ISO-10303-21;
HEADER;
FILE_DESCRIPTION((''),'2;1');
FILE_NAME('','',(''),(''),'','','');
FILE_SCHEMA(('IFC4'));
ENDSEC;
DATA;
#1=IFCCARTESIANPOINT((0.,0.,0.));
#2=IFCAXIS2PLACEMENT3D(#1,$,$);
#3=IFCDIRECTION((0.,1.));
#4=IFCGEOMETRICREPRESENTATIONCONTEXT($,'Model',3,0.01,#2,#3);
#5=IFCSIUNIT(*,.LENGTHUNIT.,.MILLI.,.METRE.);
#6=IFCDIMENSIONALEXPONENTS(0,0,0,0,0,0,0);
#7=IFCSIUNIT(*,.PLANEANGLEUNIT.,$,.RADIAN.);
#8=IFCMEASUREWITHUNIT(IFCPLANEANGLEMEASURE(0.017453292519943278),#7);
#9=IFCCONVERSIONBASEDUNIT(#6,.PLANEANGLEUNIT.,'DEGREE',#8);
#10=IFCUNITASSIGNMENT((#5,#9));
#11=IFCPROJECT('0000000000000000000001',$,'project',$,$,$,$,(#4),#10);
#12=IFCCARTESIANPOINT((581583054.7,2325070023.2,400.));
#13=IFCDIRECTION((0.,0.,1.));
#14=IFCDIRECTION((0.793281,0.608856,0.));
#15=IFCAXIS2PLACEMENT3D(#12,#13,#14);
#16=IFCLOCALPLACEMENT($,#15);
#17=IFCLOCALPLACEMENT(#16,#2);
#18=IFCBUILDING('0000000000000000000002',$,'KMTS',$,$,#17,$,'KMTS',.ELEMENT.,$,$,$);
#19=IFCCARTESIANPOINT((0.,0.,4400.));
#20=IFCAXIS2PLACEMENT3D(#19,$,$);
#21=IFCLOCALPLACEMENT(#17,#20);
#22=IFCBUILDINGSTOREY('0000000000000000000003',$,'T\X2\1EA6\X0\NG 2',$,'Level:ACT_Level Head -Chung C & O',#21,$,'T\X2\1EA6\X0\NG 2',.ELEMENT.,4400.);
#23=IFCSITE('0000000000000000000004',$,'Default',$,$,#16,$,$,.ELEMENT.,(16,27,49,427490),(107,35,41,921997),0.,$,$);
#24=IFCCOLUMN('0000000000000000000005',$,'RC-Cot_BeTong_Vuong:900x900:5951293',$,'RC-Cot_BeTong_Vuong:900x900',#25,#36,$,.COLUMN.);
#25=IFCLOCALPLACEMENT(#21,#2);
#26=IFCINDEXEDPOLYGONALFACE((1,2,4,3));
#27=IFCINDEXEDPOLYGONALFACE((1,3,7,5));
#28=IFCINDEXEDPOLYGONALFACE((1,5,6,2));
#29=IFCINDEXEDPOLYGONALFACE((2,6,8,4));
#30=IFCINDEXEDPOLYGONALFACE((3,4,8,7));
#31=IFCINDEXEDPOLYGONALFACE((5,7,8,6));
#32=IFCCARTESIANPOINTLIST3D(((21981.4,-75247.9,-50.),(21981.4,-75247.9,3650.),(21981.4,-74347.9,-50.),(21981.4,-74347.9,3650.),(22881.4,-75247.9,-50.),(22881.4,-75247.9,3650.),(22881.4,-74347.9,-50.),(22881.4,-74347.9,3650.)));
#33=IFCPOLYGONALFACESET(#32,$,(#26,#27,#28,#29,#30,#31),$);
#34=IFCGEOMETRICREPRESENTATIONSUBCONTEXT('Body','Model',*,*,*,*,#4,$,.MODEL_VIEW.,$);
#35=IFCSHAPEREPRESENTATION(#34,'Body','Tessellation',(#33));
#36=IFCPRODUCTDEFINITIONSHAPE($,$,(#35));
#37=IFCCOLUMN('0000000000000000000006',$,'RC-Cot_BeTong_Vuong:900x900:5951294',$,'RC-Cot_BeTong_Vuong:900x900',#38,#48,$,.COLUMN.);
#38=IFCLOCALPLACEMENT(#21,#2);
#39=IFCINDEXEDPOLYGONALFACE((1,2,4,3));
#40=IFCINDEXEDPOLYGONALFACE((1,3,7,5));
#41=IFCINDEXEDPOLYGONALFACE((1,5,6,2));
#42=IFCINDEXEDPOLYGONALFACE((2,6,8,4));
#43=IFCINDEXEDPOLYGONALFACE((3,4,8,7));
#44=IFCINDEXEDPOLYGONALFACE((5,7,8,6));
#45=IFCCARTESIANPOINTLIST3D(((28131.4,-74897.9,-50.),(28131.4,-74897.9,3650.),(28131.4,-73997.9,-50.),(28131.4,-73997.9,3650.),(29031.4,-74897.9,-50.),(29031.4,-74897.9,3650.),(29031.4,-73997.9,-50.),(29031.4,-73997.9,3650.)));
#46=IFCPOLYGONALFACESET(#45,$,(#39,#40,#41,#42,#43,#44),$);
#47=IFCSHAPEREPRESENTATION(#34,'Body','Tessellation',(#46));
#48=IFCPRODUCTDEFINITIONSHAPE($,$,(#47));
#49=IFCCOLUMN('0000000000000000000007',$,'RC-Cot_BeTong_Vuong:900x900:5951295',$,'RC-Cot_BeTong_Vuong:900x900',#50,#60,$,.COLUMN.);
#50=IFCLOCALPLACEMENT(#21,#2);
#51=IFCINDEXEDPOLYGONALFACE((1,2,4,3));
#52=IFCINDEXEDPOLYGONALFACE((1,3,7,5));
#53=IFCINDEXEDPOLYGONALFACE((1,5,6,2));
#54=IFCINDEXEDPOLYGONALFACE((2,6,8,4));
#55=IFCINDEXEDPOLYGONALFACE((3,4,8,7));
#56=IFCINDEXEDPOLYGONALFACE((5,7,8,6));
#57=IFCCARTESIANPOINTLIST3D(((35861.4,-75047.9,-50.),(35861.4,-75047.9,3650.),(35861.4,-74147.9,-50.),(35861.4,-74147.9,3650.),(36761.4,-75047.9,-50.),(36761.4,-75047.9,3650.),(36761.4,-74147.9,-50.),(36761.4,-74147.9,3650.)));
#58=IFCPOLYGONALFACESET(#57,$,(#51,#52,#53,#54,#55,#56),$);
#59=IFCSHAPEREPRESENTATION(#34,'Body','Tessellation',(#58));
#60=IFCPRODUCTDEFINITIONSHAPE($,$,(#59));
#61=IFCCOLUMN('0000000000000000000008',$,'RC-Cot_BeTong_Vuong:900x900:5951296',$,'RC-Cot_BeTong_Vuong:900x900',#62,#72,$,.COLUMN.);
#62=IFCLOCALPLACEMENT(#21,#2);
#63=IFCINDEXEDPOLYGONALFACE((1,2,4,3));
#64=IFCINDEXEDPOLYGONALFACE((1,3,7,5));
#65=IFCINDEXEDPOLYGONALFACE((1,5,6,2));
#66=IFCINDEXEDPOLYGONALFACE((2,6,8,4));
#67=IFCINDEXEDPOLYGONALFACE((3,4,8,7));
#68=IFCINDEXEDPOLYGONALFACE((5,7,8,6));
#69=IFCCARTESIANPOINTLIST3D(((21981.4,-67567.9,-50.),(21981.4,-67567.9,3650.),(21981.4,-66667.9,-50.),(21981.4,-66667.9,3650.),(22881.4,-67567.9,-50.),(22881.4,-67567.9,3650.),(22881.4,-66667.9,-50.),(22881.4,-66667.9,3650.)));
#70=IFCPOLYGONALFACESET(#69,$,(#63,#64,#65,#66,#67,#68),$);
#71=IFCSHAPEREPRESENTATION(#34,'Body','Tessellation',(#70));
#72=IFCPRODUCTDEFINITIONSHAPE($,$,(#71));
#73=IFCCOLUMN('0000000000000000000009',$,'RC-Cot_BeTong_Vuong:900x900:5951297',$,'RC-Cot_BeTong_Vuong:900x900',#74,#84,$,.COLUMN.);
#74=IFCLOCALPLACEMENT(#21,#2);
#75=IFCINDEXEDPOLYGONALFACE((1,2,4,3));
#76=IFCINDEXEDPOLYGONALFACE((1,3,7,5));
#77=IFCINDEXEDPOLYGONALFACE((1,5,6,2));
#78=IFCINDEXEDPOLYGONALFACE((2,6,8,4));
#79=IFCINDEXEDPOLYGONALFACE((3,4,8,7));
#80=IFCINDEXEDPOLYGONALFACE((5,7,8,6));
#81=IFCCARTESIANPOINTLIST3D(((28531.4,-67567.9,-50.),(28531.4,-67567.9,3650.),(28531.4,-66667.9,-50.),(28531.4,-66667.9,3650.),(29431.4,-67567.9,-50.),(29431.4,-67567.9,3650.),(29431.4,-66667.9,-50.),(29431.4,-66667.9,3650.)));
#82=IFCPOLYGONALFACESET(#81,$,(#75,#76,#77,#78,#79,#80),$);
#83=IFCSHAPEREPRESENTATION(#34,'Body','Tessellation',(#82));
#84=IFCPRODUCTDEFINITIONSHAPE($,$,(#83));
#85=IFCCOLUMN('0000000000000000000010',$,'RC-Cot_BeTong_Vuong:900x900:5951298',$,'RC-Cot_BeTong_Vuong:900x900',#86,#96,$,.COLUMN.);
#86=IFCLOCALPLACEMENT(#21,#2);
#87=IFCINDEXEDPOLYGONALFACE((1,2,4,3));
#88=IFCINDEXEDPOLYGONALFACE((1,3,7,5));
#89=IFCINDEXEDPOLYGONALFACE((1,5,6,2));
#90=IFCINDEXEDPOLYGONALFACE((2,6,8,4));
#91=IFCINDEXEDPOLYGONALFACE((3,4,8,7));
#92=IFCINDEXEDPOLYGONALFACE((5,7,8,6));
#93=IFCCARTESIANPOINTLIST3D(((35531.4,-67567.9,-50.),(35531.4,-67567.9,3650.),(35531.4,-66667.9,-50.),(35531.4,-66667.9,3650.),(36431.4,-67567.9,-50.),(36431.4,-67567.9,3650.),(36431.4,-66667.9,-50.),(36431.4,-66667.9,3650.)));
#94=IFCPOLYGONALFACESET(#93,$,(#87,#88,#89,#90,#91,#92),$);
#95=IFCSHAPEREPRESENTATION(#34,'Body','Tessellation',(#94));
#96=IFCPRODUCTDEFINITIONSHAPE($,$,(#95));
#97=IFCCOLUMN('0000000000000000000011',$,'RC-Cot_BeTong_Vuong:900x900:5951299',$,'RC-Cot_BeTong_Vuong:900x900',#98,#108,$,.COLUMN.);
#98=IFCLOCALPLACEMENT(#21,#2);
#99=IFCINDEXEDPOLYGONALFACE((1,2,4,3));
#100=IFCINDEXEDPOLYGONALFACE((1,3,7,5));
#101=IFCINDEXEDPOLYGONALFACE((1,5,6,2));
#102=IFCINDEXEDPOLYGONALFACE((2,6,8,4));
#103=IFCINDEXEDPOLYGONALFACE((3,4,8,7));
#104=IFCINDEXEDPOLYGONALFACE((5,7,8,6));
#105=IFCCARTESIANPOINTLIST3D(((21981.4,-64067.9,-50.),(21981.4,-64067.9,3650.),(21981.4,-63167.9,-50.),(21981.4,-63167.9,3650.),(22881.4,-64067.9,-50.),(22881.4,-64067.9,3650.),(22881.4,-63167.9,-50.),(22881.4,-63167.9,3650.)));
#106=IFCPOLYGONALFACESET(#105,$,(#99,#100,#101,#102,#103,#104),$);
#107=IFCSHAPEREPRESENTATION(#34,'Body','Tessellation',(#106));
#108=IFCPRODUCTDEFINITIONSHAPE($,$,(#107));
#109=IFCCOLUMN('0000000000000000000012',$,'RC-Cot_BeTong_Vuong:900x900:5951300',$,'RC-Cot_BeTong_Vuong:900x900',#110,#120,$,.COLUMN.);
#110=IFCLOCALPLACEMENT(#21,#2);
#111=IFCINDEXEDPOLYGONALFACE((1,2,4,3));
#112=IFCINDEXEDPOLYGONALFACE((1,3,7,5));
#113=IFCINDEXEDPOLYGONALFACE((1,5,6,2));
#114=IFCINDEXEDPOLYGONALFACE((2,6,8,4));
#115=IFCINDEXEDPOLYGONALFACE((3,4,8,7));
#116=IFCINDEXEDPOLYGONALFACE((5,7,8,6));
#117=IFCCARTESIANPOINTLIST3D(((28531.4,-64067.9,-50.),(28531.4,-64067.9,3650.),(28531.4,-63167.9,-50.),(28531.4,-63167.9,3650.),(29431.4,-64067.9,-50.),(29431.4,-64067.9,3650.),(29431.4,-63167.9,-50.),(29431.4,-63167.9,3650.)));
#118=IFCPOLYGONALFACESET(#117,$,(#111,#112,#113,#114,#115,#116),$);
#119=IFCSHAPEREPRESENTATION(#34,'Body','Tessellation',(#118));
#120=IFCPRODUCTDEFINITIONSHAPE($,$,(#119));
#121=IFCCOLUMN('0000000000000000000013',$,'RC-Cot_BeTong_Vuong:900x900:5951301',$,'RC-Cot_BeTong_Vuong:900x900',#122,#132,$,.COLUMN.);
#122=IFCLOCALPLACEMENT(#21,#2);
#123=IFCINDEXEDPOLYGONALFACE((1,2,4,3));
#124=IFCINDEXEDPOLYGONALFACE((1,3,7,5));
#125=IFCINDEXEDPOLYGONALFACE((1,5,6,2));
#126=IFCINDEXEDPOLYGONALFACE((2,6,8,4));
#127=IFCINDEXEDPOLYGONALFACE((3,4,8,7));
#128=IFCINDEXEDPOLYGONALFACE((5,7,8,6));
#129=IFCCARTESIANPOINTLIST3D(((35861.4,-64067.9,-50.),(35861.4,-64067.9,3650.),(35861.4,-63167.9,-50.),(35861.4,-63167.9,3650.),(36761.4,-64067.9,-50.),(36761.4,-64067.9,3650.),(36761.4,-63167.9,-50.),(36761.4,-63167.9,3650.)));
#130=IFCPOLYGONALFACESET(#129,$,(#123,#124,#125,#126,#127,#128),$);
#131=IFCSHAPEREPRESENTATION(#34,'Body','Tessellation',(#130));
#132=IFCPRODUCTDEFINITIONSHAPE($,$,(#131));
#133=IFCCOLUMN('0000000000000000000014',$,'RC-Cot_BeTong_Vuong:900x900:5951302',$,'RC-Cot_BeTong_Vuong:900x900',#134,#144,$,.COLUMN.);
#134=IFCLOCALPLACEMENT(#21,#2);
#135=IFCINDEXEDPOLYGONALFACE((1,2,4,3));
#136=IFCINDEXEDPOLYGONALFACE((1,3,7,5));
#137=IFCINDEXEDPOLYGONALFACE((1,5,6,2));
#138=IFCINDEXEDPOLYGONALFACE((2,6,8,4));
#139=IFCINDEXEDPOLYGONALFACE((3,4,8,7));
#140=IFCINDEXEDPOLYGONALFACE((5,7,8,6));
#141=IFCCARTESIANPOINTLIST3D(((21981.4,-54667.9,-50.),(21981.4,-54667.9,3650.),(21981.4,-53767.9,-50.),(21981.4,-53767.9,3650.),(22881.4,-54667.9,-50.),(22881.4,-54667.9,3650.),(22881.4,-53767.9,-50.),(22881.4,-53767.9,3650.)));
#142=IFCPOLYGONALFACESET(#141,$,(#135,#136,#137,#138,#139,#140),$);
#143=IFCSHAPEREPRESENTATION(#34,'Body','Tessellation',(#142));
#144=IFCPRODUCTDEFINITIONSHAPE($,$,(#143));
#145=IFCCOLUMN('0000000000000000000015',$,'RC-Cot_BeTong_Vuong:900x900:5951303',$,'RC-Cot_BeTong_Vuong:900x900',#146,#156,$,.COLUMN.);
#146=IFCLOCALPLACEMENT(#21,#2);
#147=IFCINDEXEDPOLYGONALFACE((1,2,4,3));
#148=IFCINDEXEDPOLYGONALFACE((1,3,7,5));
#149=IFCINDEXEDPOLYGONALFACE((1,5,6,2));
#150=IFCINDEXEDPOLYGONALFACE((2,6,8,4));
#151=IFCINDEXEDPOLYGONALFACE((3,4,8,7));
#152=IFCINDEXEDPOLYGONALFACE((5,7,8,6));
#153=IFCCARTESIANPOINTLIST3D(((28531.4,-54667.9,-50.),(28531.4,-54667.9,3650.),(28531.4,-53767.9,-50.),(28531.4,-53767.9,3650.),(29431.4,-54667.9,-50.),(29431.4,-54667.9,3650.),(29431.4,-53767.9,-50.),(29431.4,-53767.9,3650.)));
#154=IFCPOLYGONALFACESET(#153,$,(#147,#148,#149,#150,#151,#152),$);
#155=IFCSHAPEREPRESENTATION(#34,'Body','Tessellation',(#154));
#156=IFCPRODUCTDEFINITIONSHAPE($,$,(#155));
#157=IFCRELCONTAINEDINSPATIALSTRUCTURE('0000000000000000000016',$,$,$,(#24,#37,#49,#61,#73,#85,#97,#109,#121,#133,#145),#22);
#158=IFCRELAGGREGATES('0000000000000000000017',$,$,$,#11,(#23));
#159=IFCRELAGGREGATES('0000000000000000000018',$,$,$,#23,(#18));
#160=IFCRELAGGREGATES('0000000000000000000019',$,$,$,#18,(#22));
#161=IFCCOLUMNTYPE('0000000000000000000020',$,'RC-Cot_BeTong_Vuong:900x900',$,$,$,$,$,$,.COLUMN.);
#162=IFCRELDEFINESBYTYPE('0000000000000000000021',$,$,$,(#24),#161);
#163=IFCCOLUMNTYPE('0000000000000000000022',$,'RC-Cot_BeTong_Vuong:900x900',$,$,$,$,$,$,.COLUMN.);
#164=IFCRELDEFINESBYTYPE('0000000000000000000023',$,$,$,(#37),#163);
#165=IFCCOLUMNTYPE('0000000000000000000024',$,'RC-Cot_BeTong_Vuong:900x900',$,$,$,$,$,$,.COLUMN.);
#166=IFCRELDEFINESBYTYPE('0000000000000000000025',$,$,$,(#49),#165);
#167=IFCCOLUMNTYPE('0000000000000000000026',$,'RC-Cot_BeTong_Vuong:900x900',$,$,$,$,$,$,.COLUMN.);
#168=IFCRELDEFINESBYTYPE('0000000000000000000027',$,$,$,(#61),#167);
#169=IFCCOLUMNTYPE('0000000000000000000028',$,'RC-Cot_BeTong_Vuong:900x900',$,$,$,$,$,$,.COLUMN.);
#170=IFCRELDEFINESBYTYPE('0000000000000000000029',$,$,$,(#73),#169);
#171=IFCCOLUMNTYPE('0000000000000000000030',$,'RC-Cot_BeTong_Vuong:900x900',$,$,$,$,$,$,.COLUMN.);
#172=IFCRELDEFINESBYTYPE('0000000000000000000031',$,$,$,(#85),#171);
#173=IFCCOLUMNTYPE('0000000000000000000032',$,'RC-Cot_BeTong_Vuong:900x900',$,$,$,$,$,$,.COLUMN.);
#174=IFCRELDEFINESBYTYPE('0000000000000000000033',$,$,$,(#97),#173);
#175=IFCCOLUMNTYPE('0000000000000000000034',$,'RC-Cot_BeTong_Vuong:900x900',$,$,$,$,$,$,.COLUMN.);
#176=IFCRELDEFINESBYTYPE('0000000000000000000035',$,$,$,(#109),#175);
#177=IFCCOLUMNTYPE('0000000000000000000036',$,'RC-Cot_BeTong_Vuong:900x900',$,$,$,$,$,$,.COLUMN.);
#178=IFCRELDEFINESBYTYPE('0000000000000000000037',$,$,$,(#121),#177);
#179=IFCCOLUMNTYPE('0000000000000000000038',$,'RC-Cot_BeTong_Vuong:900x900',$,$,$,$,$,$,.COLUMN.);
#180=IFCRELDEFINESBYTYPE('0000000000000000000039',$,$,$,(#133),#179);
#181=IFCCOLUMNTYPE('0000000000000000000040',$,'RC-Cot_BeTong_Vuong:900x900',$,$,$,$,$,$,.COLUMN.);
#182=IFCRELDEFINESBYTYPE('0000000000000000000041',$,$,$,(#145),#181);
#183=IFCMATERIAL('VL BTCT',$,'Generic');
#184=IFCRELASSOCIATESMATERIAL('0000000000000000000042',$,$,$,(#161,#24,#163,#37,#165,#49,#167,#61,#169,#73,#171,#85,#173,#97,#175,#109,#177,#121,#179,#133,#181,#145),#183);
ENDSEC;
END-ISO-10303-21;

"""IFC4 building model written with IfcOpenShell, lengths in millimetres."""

from ifc_helpers import new_model, entity, si_unit, converted_unit, direction, frame, origin, place, context, subcontext, project, spatial, indexed_curve, outline, extrude, source, transform, mapped, material, type_object, type_shapes, element, save


model = new_model("IFC4")

# Units and contexts
model_context = context("Model", 3, precision=0.01, world=origin(), true_north=direction((0.0, 1.0)))
body_context = subcontext(model_context, "Body", "Model", "MODEL_VIEW")
ifc_project = project(units=[si_unit("LENGTHUNIT", "METRE", prefix="MILLI"), converted_unit("PLANEANGLEUNIT", "DEGREE", entity("IfcPlaneAngleMeasure", 0.017453292519943278), si_unit("PLANEANGLEUNIT", "RADIAN"), dimensions=[0, 0, 0, 0, 0, 0, 0])], contexts=[model_context])

# Site, building, storey
site_placement = place(None, frame((581583054.7, 2325070023.2, 400.0), z_axis=(0.0, 0.0, 1.0), x_axis=(0.793281, 0.608856, 0.0)))
site = spatial("IfcSite", under=ifc_project, at=site_placement, Name="Default", CompositionType="ELEMENT", RefLatitude=(16, 27, 49, 427490), RefLongitude=(107, 35, 41, 921997), RefElevation=0.0)
building_placement = place(site_placement, origin())
building = spatial("IfcBuilding", under=site, at=building_placement, Name="KMTS", LongName="KMTS", CompositionType="ELEMENT")
storey_placement = place(building_placement, frame((0.0, 0.0, 4400.0)))
storey = spatial("IfcBuildingStorey", under=building, at=storey_placement, Name="TẦNG 2", ObjectType="Level:ACT_Level Head -Chung C & O", LongName="TẦNG 2", CompositionType="ELEMENT", Elevation=4400.0)

# Columns
ifc_material_1 = material(Name="VL BTCT", Category="Generic")
column_type_1 = type_object("IfcColumnType", Name="RC-Cot_BeTong_Vuong:900x900", PredefinedType="COLUMN", material=ifc_material_1)
shared_shape_1 = source(origin(), body_context, "Body", "SweptSolid", [
    extrude(outline(indexed_curve([(-450.0, -450.0), (450.0, -450.0), (450.0, 450.0), (-450.0, 450.0), (-450.0, -450.0)], self_intersect=False)), frame((22431.4, -74797.9, 4350.0), z_axis=(0.0, 0.0, 1.0), x_axis=(-1.0, 0.0, 0.0)), (0.0, 0.0, 1.0), 3700.0),
])
type_shapes(column_type_1, [shared_shape_1])
column_1_placement = place(storey_placement, frame((0.0, 0.0, -4400.0)))
element("IfcColumn", 1, at=column_1_placement, inside=storey, type_object=column_type_1, material=ifc_material_1, Name="RC-Cot_BeTong_Vuong:900x900:5951293", ObjectType="RC-Cot_BeTong_Vuong:900x900", PredefinedType="COLUMN", context=body_context, shape_type="MappedRepresentation", body=[
    mapped(shared_shape_1, transform((0.0, 0.0, 0.0), scale=1.0)),
])
column_type_2 = type_object("IfcColumnType", Name="RC-Cot_BeTong_Vuong:900x900", PredefinedType="COLUMN", material=ifc_material_1)
shared_shape_2 = source(origin(), body_context, "Body", "SweptSolid", [
    extrude(outline(indexed_curve([(-450.0, -450.0), (450.0, -450.0), (450.0, 450.0), (-450.0, 450.0), (-450.0, -450.0)], self_intersect=False)), frame((28581.4, -74447.9, 4350.0), z_axis=(0.0, 0.0, 1.0), x_axis=(-1.0, 0.0, 0.0)), (0.0, 0.0, 1.0), 3700.0),
])
type_shapes(column_type_2, [shared_shape_2])
column_2_placement = place(storey_placement, frame((0.0, 0.0, -4400.0)))
element("IfcColumn", 2, at=column_2_placement, inside=storey, type_object=column_type_2, material=ifc_material_1, Name="RC-Cot_BeTong_Vuong:900x900:5951294", ObjectType="RC-Cot_BeTong_Vuong:900x900", PredefinedType="COLUMN", context=body_context, shape_type="MappedRepresentation", body=[
    mapped(shared_shape_2, transform((0.0, 0.0, 0.0), scale=1.0)),
])
column_type_3 = type_object("IfcColumnType", Name="RC-Cot_BeTong_Vuong:900x900", PredefinedType="COLUMN", material=ifc_material_1)
shared_shape_3 = source(origin(), body_context, "Body", "SweptSolid", [
    extrude(outline(indexed_curve([(-450.0, -450.0), (450.0, -450.0), (450.0, 450.0), (-450.0, 450.0), (-450.0, -450.0)], self_intersect=False)), frame((36311.4, -74597.9, 4350.0), z_axis=(0.0, 0.0, 1.0), x_axis=(-1.0, 0.0, 0.0)), (0.0, 0.0, 1.0), 3700.0),
])
type_shapes(column_type_3, [shared_shape_3])
column_3_placement = place(storey_placement, frame((0.0, 0.0, -4400.0)))
element("IfcColumn", 3, at=column_3_placement, inside=storey, type_object=column_type_3, material=ifc_material_1, Name="RC-Cot_BeTong_Vuong:900x900:5951295", ObjectType="RC-Cot_BeTong_Vuong:900x900", PredefinedType="COLUMN", context=body_context, shape_type="MappedRepresentation", body=[
    mapped(shared_shape_3, transform((0.0, 0.0, 0.0), scale=1.0)),
])
column_type_4 = type_object("IfcColumnType", Name="RC-Cot_BeTong_Vuong:900x900", PredefinedType="COLUMN", material=ifc_material_1)
shared_shape_4 = source(origin(), body_context, "Body", "SweptSolid", [
    extrude(outline(indexed_curve([(-450.0, -450.0), (450.0, -450.0), (450.0, 450.0), (-450.0, 450.0), (-450.0, -450.0)], self_intersect=False)), frame((22431.4, -67117.9, 4350.0), z_axis=(0.0, 0.0, 1.0), x_axis=(-1.0, 0.0, 0.0)), (0.0, 0.0, 1.0), 3700.0),
])
type_shapes(column_type_4, [shared_shape_4])
column_4_placement = place(storey_placement, frame((0.0, 0.0, -4400.0)))
element("IfcColumn", 4, at=column_4_placement, inside=storey, type_object=column_type_4, material=ifc_material_1, Name="RC-Cot_BeTong_Vuong:900x900:5951296", ObjectType="RC-Cot_BeTong_Vuong:900x900", PredefinedType="COLUMN", context=body_context, shape_type="MappedRepresentation", body=[
    mapped(shared_shape_4, transform((0.0, 0.0, 0.0), scale=1.0)),
])
column_type_5 = type_object("IfcColumnType", Name="RC-Cot_BeTong_Vuong:900x900", PredefinedType="COLUMN", material=ifc_material_1)
shared_shape_5 = source(origin(), body_context, "Body", "SweptSolid", [
    extrude(outline(indexed_curve([(-450.0, -450.0), (450.0, -450.0), (450.0, 450.0), (-450.0, 450.0), (-450.0, -450.0)], self_intersect=False)), frame((28981.4, -67117.9, 4350.0), z_axis=(0.0, 0.0, 1.0), x_axis=(-1.0, 0.0, 0.0)), (0.0, 0.0, 1.0), 3700.0),
])
type_shapes(column_type_5, [shared_shape_5])
column_5_placement = place(storey_placement, frame((0.0, 0.0, -4400.0)))
element("IfcColumn", 5, at=column_5_placement, inside=storey, type_object=column_type_5, material=ifc_material_1, Name="RC-Cot_BeTong_Vuong:900x900:5951297", ObjectType="RC-Cot_BeTong_Vuong:900x900", PredefinedType="COLUMN", context=body_context, shape_type="MappedRepresentation", body=[
    mapped(shared_shape_5, transform((0.0, 0.0, 0.0), scale=1.0)),
])
column_type_6 = type_object("IfcColumnType", Name="RC-Cot_BeTong_Vuong:900x900", PredefinedType="COLUMN", material=ifc_material_1)
shared_shape_6 = source(origin(), body_context, "Body", "SweptSolid", [
    extrude(outline(indexed_curve([(-450.0, -450.0), (450.0, -450.0), (450.0, 450.0), (-450.0, 450.0), (-450.0, -450.0)], self_intersect=False)), frame((35981.4, -67117.9, 4350.0), z_axis=(0.0, 0.0, 1.0), x_axis=(-1.0, 0.0, 0.0)), (0.0, 0.0, 1.0), 3700.0),
])
type_shapes(column_type_6, [shared_shape_6])
column_6_placement = place(storey_placement, frame((0.0, 0.0, -4400.0)))
element("IfcColumn", 6, at=column_6_placement, inside=storey, type_object=column_type_6, material=ifc_material_1, Name="RC-Cot_BeTong_Vuong:900x900:5951298", ObjectType="RC-Cot_BeTong_Vuong:900x900", PredefinedType="COLUMN", context=body_context, shape_type="MappedRepresentation", body=[
    mapped(shared_shape_6, transform((0.0, 0.0, 0.0), scale=1.0)),
])
column_type_7 = type_object("IfcColumnType", Name="RC-Cot_BeTong_Vuong:900x900", PredefinedType="COLUMN", material=ifc_material_1)
shared_shape_7 = source(origin(), body_context, "Body", "SweptSolid", [
    extrude(outline(indexed_curve([(-450.0, -450.0), (450.0, -450.0), (450.0, 450.0), (-450.0, 450.0), (-450.0, -450.0)], self_intersect=False)), frame((22431.4, -63617.9, 4350.0), z_axis=(0.0, 0.0, 1.0), x_axis=(-1.0, 0.0, 0.0)), (0.0, 0.0, 1.0), 3700.0),
])
type_shapes(column_type_7, [shared_shape_7])
column_7_placement = place(storey_placement, frame((0.0, 0.0, -4400.0)))
element("IfcColumn", 7, at=column_7_placement, inside=storey, type_object=column_type_7, material=ifc_material_1, Name="RC-Cot_BeTong_Vuong:900x900:5951299", ObjectType="RC-Cot_BeTong_Vuong:900x900", PredefinedType="COLUMN", context=body_context, shape_type="MappedRepresentation", body=[
    mapped(shared_shape_7, transform((0.0, 0.0, 0.0), scale=1.0)),
])
column_type_8 = type_object("IfcColumnType", Name="RC-Cot_BeTong_Vuong:900x900", PredefinedType="COLUMN", material=ifc_material_1)
shared_shape_8 = source(origin(), body_context, "Body", "SweptSolid", [
    extrude(outline(indexed_curve([(-450.0, -450.0), (450.0, -450.0), (450.0, 450.0), (-450.0, 450.0), (-450.0, -450.0)], self_intersect=False)), frame((28981.4, -63617.9, 4350.0), z_axis=(0.0, 0.0, 1.0), x_axis=(-1.0, 0.0, 0.0)), (0.0, 0.0, 1.0), 3700.0),
])
type_shapes(column_type_8, [shared_shape_8])
column_8_placement = place(storey_placement, frame((0.0, 0.0, -4400.0)))
element("IfcColumn", 8, at=column_8_placement, inside=storey, type_object=column_type_8, material=ifc_material_1, Name="RC-Cot_BeTong_Vuong:900x900:5951300", ObjectType="RC-Cot_BeTong_Vuong:900x900", PredefinedType="COLUMN", context=body_context, shape_type="MappedRepresentation", body=[
    mapped(shared_shape_8, transform((0.0, 0.0, 0.0), scale=1.0)),
])
column_type_9 = type_object("IfcColumnType", Name="RC-Cot_BeTong_Vuong:900x900", PredefinedType="COLUMN", material=ifc_material_1)
shared_shape_9 = source(origin(), body_context, "Body", "SweptSolid", [
    extrude(outline(indexed_curve([(-450.0, -450.0), (450.0, -450.0), (450.0, 450.0), (-450.0, 450.0), (-450.0, -450.0)], self_intersect=False)), frame((36311.4, -63617.9, 4350.0), z_axis=(0.0, 0.0, 1.0), x_axis=(-1.0, 0.0, 0.0)), (0.0, 0.0, 1.0), 3700.0),
])
type_shapes(column_type_9, [shared_shape_9])
column_9_placement = place(storey_placement, frame((0.0, 0.0, -4400.0)))
element("IfcColumn", 9, at=column_9_placement, inside=storey, type_object=column_type_9, material=ifc_material_1, Name="RC-Cot_BeTong_Vuong:900x900:5951301", ObjectType="RC-Cot_BeTong_Vuong:900x900", PredefinedType="COLUMN", context=body_context, shape_type="MappedRepresentation", body=[
    mapped(shared_shape_9, transform((0.0, 0.0, 0.0), scale=1.0)),
])
column_type_10 = type_object("IfcColumnType", Name="RC-Cot_BeTong_Vuong:900x900", PredefinedType="COLUMN", material=ifc_material_1)
shared_shape_10 = source(origin(), body_context, "Body", "SweptSolid", [
    extrude(outline(indexed_curve([(-450.0, -450.0), (450.0, -450.0), (450.0, 450.0), (-450.0, 450.0), (-450.0, -450.0)], self_intersect=False)), frame((22431.4, -54217.9, 4350.0), z_axis=(0.0, 0.0, 1.0), x_axis=(-1.0, 0.0, 0.0)), (0.0, 0.0, 1.0), 3700.0),
])
type_shapes(column_type_10, [shared_shape_10])
column_10_placement = place(storey_placement, frame((0.0, 0.0, -4400.0)))
element("IfcColumn", 10, at=column_10_placement, inside=storey, type_object=column_type_10, material=ifc_material_1, Name="RC-Cot_BeTong_Vuong:900x900:5951302", ObjectType="RC-Cot_BeTong_Vuong:900x900", PredefinedType="COLUMN", context=body_context, shape_type="MappedRepresentation", body=[
    mapped(shared_shape_10, transform((0.0, 0.0, 0.0), scale=1.0)),
])
column_type_11 = type_object("IfcColumnType", Name="RC-Cot_BeTong_Vuong:900x900", PredefinedType="COLUMN", material=ifc_material_1)
shared_shape_11 = source(origin(), body_context, "Body", "SweptSolid", [
    extrude(outline(indexed_curve([(-450.0, -450.0), (450.0, -450.0), (450.0, 450.0), (-450.0, 450.0), (-450.0, -450.0)], self_intersect=False)), frame((28981.4, -54217.9, 4350.0), z_axis=(0.0, 0.0, 1.0), x_axis=(-1.0, 0.0, 0.0)), (0.0, 0.0, 1.0), 3700.0),
])
type_shapes(column_type_11, [shared_shape_11])
column_11_placement = place(storey_placement, frame((0.0, 0.0, -4400.0)))
element("IfcColumn", 11, at=column_11_placement, inside=storey, type_object=column_type_11, material=ifc_material_1, Name="RC-Cot_BeTong_Vuong:900x900:5951303", ObjectType="RC-Cot_BeTong_Vuong:900x900", PredefinedType="COLUMN", context=body_context, shape_type="MappedRepresentation", body=[
    mapped(shared_shape_11, transform((0.0, 0.0, 0.0), scale=1.0)),
])

save(model, "model.ifc")
